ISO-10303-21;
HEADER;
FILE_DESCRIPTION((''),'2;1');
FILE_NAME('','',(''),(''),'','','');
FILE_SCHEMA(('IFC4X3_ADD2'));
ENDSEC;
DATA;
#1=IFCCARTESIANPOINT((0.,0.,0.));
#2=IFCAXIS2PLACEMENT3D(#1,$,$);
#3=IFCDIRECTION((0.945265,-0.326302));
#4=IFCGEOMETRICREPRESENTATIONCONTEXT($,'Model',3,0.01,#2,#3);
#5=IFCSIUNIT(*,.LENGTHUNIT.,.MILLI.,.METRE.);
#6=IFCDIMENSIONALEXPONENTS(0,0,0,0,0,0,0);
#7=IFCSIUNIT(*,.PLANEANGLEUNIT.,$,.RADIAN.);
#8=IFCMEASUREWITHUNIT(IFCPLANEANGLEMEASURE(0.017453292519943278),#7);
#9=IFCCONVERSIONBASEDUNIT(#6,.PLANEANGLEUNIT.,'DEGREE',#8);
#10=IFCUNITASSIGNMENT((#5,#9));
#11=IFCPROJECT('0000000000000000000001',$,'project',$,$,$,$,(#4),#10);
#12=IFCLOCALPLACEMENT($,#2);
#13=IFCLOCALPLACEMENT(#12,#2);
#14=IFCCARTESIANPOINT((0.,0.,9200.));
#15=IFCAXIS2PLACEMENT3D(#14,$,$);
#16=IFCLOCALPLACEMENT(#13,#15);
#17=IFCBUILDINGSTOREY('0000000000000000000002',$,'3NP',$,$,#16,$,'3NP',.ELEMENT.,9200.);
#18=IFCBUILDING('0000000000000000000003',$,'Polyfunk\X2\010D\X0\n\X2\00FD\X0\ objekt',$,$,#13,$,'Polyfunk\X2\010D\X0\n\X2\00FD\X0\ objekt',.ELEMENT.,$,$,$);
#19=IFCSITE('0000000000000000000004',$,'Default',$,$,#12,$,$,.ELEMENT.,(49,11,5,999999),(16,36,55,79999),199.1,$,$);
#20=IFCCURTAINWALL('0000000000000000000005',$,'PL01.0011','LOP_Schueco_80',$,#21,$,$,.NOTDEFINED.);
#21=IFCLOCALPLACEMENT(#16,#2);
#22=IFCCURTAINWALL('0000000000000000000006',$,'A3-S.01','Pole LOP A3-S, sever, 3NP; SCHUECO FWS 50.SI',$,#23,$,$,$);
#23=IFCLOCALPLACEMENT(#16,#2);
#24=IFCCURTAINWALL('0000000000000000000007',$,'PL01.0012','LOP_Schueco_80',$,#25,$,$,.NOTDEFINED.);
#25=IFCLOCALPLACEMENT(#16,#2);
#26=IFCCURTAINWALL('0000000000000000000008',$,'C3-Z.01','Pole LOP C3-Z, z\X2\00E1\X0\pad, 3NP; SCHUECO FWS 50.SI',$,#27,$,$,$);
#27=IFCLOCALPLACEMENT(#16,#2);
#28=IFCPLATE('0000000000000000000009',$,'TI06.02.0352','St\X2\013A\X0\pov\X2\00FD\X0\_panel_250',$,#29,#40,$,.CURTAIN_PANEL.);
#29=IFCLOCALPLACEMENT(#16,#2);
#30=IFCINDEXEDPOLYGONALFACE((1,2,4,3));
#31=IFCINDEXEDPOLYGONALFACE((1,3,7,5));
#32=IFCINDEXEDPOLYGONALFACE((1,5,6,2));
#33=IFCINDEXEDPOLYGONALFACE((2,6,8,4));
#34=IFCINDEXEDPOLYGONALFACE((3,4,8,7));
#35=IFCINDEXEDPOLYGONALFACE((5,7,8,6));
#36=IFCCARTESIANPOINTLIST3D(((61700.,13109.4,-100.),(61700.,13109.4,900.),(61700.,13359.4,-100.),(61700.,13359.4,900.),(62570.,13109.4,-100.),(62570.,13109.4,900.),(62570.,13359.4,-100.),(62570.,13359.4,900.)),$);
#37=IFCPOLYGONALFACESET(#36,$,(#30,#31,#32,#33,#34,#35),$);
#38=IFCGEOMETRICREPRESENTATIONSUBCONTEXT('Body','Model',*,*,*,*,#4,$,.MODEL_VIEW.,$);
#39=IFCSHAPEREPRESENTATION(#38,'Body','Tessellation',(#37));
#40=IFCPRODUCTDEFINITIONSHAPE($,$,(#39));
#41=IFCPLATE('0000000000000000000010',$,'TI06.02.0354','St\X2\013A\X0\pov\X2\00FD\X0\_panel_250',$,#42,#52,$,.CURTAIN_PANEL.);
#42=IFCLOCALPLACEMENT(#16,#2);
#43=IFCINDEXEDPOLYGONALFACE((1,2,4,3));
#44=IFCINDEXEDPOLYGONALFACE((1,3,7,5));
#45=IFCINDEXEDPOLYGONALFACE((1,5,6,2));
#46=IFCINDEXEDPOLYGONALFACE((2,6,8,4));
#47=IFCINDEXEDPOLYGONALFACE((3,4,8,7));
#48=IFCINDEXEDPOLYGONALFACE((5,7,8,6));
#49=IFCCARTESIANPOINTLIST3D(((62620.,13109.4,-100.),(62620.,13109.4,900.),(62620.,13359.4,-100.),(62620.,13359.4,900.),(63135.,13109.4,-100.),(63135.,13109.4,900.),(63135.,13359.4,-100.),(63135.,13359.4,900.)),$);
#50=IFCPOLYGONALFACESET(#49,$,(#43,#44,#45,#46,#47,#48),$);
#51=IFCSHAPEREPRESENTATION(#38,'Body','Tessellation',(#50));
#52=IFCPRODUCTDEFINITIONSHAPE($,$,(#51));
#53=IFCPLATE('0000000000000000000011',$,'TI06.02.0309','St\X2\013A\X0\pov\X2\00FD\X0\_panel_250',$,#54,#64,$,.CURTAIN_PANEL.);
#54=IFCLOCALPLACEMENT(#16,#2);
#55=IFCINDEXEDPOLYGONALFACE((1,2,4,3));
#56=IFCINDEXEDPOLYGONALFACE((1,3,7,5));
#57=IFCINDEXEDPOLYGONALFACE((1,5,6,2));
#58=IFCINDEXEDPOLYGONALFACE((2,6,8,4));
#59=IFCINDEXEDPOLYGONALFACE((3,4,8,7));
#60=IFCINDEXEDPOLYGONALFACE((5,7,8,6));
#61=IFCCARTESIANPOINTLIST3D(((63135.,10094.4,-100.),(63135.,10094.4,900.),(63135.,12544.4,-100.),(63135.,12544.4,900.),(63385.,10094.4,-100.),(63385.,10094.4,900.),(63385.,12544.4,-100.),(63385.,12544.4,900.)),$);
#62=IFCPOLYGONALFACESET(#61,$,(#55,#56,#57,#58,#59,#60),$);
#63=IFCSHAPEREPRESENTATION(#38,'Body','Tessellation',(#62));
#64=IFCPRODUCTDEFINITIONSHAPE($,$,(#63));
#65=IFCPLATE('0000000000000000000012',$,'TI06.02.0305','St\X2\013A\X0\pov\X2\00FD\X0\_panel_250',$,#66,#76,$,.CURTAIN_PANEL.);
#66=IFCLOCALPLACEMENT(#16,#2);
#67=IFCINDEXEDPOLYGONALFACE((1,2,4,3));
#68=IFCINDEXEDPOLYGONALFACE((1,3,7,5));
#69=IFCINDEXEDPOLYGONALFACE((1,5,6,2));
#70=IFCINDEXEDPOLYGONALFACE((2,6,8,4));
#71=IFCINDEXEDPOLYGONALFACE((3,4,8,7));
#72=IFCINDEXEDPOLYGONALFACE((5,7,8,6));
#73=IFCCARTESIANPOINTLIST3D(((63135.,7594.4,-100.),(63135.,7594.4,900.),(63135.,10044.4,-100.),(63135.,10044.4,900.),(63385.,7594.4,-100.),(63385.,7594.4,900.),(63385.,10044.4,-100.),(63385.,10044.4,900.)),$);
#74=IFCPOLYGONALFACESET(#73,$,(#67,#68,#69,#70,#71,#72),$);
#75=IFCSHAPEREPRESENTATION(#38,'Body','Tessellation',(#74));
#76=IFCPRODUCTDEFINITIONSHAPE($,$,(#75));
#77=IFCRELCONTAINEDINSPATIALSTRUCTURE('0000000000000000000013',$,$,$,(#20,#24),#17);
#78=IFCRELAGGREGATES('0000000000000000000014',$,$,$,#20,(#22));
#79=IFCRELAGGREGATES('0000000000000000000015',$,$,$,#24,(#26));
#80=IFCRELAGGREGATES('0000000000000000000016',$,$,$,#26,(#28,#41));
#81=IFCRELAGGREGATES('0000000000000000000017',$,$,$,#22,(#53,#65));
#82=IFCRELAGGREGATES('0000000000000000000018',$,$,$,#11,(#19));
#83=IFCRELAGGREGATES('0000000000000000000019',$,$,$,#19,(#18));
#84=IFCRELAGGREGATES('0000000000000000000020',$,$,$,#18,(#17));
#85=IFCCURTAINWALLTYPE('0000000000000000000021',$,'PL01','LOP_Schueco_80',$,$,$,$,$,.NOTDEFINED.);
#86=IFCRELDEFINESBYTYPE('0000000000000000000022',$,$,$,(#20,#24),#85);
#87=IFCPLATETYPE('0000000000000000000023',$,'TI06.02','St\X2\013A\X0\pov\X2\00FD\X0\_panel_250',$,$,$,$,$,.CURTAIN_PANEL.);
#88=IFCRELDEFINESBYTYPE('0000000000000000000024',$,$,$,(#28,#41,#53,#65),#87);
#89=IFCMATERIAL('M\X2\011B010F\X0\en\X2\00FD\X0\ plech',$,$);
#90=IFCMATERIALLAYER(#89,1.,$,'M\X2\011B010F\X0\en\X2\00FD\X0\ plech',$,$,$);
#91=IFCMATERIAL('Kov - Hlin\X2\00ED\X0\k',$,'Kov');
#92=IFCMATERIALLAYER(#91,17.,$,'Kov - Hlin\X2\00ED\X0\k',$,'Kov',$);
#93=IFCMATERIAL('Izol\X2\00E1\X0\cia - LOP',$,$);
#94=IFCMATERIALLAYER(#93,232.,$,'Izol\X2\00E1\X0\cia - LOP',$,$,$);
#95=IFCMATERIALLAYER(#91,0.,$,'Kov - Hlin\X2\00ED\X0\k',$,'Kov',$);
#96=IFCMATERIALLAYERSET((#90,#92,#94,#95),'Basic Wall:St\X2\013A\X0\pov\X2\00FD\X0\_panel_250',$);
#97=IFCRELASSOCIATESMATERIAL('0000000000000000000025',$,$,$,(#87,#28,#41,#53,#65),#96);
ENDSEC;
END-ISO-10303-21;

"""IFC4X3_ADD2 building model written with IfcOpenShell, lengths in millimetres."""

from ifc_helpers import new_model, entity, si_unit, converted_unit, direction, frame, frame_2d, origin, origin_2d_with_axis, place, context, subcontext, project, spatial, rectangle, extrude, material, layer, layer_set, layer_usage, type_object, element, aggregate, save


model = new_model("IFC4X3_ADD2")

# Units and contexts
model_context = context("Model", 3, precision=0.01, world=origin(), true_north=direction((0.945265, -0.326302)))
body_context = subcontext(model_context, "Body", "Model", "MODEL_VIEW")
ifc_project = project(units=[si_unit("LENGTHUNIT", "METRE", prefix="MILLI"), converted_unit("PLANEANGLEUNIT", "DEGREE", entity("IfcPlaneAngleMeasure", 0.017453292519943278), si_unit("PLANEANGLEUNIT", "RADIAN"), dimensions=[0, 0, 0, 0, 0, 0, 0])], contexts=[model_context])

# Site, building, storey
site_placement = place(None, origin())
site = spatial("IfcSite", under=ifc_project, at=site_placement, Name="Default", CompositionType="ELEMENT", RefLatitude=(49, 11, 5, 999999), RefLongitude=(16, 36, 55, 79999), RefElevation=199.1)
building_placement = place(site_placement, origin())
building = spatial("IfcBuilding", under=site, at=building_placement, Name="Polyfunkčný objekt", LongName="Polyfunkčný objekt", CompositionType="ELEMENT")
storey_placement = place(building_placement, frame((0.0, 0.0, 9200.0)))
storey = spatial("IfcBuildingStorey", under=building, at=storey_placement, Name="3NP", LongName="3NP", CompositionType="ELEMENT", Elevation=9200.0)

# Curtain walls
curtain_wall_type = type_object("IfcCurtainWallType", Name="PL01", Description="LOP_Schueco_80", PredefinedType="NOTDEFINED")
curtain_wall_1_placement = place(storey_placement, frame((0.0, 0.0, -9200.0)))
curtain_wall_1 = element("IfcCurtainWall", 1, at=curtain_wall_1_placement, inside=storey, type_object=curtain_wall_type, Name="PL01.0011", Description="LOP_Schueco_80", PredefinedType="NOTDEFINED")
curtain_wall_2 = element("IfcCurtainWall", 2, Name="A3-S.01", Description="Pole LOP A3-S, sever, 3NP; SCHUECO FWS 50.SI")
aggregate(curtain_wall_1, [curtain_wall_2])

# Curtain walls
curtain_wall_3_placement = place(storey_placement, frame((0.0, 0.0, -9200.0)))
curtain_wall_3 = element("IfcCurtainWall", 3, at=curtain_wall_3_placement, inside=storey, type_object=curtain_wall_type, Name="PL01.0012", Description="LOP_Schueco_80", PredefinedType="NOTDEFINED")
curtain_wall_4 = element("IfcCurtainWall", 4, Name="C3-Z.01", Description="Pole LOP C3-Z, západ, 3NP; SCHUECO FWS 50.SI")
aggregate(curtain_wall_3, [curtain_wall_4])

# Plates
ifc_material_1 = material(Name="Měďený plech")
ifc_layer_1 = layer(ifc_material_1, 1.0, Name="Měďený plech")
ifc_material_2 = material(Name="Kov - Hliník", Category="Kov")
ifc_layer_2 = layer(ifc_material_2, 17.0, Name="Kov - Hliník", Category="Kov")
ifc_material_3 = material(Name="Izolácia - LOP")
ifc_layer_3 = layer(ifc_material_3, 232.0, Name="Izolácia - LOP")
ifc_layer_4 = layer(ifc_material_2, 0.0, Name="Kov - Hliník", Category="Kov")
ifc_layer_set = layer_set([ifc_layer_1, ifc_layer_2, ifc_layer_3, ifc_layer_4], Name="Basic Wall:Stĺpový_panel_250")
ifc_layer_usage_1 = layer_usage(ifc_layer_set, "AXIS2", "NEGATIVE", 125.0)
plate_type = type_object("IfcPlateType", Name="TI06.02", Description="Stĺpový_panel_250", PredefinedType="CURTAIN_PANEL", material=ifc_layer_set)
plate_1_placement = place(storey_placement, frame((61700.0, 13234.4, -100.0)))
plate_1 = element("IfcPlate", 5, at=plate_1_placement, type_object=plate_type, material=ifc_layer_usage_1, Name="TI06.02.0352", Description="Stĺpový_panel_250", PredefinedType="CURTAIN_PANEL", context=body_context, shape_type="SweptSolid", body=[
    extrude(rectangle(XDim=250.0, YDim=870.0, at=frame_2d((0.0, 0.0), x_axis=(1.0, 0.0))), frame((435.0, 0.0, 0.0), z_axis=(0.0, 0.0, 1.0), x_axis=(0.0, 1.0, 0.0)), (0.0, 0.0, 1.0), 1000.0),
])
ifc_layer_usage_2 = layer_usage(ifc_layer_set, "AXIS2", "NEGATIVE", 125.0)
plate_2_placement = place(storey_placement, frame((62620.0, 13234.4, -100.0)))
plate_2 = element("IfcPlate", 6, at=plate_2_placement, type_object=plate_type, material=ifc_layer_usage_2, Name="TI06.02.0354", Description="Stĺpový_panel_250", PredefinedType="CURTAIN_PANEL", context=body_context, shape_type="SweptSolid", body=[
    extrude(rectangle(XDim=250.0, YDim=515.0, at=frame_2d((0.0, 0.0), x_axis=(1.0, 0.0))), frame((257.5, 0.0, 0.0), z_axis=(0.0, 0.0, 1.0), x_axis=(0.0, 1.0, 0.0)), (0.0, 0.0, 1.0), 1000.0),
])
aggregate(curtain_wall_4, [plate_1, plate_2])
ifc_layer_usage_3 = layer_usage(ifc_layer_set, "AXIS2", "NEGATIVE", 125.0)
plate_3_placement = place(storey_placement, frame((63260.0, 12544.4, -100.0), z_axis=(0.0, 0.0, 1.0), x_axis=(0.0, -1.0, 0.0)))
plate_3 = element("IfcPlate", 7, at=plate_3_placement, type_object=plate_type, material=ifc_layer_usage_3, Name="TI06.02.0309", Description="Stĺpový_panel_250", PredefinedType="CURTAIN_PANEL", context=body_context, shape_type="SweptSolid", body=[
    extrude(rectangle(XDim=250.0, YDim=2450.0, at=frame_2d((0.0, 0.0), x_axis=(1.0, 0.0))), frame((1225.0, 0.0, 0.0), z_axis=(0.0, 0.0, 1.0), x_axis=(0.0, 1.0, 0.0)), (0.0, 0.0, 1.0), 1000.0),
])
ifc_layer_usage_4 = layer_usage(ifc_layer_set, "AXIS2", "NEGATIVE", 125.0)
plate_4_placement = place(storey_placement, frame((63260.0, 10044.4, -100.0), z_axis=(0.0, 0.0, 1.0), x_axis=(0.0, -1.0, 0.0)))
plate_4 = element("IfcPlate", 8, at=plate_4_placement, type_object=plate_type, material=ifc_layer_usage_4, Name="TI06.02.0305", Description="Stĺpový_panel_250", PredefinedType="CURTAIN_PANEL", context=body_context, shape_type="SweptSolid", body=[
    extrude(rectangle(XDim=250.0, YDim=2450.0, at=origin_2d_with_axis()), frame((1225.0, 0.0, 0.0), z_axis=(0.0, 0.0, 1.0), x_axis=(0.0, 1.0, 0.0)), (0.0, 0.0, 1.0), 1000.0),
])
aggregate(curtain_wall_2, [plate_3, plate_4])

save(model, "model.ifc")
